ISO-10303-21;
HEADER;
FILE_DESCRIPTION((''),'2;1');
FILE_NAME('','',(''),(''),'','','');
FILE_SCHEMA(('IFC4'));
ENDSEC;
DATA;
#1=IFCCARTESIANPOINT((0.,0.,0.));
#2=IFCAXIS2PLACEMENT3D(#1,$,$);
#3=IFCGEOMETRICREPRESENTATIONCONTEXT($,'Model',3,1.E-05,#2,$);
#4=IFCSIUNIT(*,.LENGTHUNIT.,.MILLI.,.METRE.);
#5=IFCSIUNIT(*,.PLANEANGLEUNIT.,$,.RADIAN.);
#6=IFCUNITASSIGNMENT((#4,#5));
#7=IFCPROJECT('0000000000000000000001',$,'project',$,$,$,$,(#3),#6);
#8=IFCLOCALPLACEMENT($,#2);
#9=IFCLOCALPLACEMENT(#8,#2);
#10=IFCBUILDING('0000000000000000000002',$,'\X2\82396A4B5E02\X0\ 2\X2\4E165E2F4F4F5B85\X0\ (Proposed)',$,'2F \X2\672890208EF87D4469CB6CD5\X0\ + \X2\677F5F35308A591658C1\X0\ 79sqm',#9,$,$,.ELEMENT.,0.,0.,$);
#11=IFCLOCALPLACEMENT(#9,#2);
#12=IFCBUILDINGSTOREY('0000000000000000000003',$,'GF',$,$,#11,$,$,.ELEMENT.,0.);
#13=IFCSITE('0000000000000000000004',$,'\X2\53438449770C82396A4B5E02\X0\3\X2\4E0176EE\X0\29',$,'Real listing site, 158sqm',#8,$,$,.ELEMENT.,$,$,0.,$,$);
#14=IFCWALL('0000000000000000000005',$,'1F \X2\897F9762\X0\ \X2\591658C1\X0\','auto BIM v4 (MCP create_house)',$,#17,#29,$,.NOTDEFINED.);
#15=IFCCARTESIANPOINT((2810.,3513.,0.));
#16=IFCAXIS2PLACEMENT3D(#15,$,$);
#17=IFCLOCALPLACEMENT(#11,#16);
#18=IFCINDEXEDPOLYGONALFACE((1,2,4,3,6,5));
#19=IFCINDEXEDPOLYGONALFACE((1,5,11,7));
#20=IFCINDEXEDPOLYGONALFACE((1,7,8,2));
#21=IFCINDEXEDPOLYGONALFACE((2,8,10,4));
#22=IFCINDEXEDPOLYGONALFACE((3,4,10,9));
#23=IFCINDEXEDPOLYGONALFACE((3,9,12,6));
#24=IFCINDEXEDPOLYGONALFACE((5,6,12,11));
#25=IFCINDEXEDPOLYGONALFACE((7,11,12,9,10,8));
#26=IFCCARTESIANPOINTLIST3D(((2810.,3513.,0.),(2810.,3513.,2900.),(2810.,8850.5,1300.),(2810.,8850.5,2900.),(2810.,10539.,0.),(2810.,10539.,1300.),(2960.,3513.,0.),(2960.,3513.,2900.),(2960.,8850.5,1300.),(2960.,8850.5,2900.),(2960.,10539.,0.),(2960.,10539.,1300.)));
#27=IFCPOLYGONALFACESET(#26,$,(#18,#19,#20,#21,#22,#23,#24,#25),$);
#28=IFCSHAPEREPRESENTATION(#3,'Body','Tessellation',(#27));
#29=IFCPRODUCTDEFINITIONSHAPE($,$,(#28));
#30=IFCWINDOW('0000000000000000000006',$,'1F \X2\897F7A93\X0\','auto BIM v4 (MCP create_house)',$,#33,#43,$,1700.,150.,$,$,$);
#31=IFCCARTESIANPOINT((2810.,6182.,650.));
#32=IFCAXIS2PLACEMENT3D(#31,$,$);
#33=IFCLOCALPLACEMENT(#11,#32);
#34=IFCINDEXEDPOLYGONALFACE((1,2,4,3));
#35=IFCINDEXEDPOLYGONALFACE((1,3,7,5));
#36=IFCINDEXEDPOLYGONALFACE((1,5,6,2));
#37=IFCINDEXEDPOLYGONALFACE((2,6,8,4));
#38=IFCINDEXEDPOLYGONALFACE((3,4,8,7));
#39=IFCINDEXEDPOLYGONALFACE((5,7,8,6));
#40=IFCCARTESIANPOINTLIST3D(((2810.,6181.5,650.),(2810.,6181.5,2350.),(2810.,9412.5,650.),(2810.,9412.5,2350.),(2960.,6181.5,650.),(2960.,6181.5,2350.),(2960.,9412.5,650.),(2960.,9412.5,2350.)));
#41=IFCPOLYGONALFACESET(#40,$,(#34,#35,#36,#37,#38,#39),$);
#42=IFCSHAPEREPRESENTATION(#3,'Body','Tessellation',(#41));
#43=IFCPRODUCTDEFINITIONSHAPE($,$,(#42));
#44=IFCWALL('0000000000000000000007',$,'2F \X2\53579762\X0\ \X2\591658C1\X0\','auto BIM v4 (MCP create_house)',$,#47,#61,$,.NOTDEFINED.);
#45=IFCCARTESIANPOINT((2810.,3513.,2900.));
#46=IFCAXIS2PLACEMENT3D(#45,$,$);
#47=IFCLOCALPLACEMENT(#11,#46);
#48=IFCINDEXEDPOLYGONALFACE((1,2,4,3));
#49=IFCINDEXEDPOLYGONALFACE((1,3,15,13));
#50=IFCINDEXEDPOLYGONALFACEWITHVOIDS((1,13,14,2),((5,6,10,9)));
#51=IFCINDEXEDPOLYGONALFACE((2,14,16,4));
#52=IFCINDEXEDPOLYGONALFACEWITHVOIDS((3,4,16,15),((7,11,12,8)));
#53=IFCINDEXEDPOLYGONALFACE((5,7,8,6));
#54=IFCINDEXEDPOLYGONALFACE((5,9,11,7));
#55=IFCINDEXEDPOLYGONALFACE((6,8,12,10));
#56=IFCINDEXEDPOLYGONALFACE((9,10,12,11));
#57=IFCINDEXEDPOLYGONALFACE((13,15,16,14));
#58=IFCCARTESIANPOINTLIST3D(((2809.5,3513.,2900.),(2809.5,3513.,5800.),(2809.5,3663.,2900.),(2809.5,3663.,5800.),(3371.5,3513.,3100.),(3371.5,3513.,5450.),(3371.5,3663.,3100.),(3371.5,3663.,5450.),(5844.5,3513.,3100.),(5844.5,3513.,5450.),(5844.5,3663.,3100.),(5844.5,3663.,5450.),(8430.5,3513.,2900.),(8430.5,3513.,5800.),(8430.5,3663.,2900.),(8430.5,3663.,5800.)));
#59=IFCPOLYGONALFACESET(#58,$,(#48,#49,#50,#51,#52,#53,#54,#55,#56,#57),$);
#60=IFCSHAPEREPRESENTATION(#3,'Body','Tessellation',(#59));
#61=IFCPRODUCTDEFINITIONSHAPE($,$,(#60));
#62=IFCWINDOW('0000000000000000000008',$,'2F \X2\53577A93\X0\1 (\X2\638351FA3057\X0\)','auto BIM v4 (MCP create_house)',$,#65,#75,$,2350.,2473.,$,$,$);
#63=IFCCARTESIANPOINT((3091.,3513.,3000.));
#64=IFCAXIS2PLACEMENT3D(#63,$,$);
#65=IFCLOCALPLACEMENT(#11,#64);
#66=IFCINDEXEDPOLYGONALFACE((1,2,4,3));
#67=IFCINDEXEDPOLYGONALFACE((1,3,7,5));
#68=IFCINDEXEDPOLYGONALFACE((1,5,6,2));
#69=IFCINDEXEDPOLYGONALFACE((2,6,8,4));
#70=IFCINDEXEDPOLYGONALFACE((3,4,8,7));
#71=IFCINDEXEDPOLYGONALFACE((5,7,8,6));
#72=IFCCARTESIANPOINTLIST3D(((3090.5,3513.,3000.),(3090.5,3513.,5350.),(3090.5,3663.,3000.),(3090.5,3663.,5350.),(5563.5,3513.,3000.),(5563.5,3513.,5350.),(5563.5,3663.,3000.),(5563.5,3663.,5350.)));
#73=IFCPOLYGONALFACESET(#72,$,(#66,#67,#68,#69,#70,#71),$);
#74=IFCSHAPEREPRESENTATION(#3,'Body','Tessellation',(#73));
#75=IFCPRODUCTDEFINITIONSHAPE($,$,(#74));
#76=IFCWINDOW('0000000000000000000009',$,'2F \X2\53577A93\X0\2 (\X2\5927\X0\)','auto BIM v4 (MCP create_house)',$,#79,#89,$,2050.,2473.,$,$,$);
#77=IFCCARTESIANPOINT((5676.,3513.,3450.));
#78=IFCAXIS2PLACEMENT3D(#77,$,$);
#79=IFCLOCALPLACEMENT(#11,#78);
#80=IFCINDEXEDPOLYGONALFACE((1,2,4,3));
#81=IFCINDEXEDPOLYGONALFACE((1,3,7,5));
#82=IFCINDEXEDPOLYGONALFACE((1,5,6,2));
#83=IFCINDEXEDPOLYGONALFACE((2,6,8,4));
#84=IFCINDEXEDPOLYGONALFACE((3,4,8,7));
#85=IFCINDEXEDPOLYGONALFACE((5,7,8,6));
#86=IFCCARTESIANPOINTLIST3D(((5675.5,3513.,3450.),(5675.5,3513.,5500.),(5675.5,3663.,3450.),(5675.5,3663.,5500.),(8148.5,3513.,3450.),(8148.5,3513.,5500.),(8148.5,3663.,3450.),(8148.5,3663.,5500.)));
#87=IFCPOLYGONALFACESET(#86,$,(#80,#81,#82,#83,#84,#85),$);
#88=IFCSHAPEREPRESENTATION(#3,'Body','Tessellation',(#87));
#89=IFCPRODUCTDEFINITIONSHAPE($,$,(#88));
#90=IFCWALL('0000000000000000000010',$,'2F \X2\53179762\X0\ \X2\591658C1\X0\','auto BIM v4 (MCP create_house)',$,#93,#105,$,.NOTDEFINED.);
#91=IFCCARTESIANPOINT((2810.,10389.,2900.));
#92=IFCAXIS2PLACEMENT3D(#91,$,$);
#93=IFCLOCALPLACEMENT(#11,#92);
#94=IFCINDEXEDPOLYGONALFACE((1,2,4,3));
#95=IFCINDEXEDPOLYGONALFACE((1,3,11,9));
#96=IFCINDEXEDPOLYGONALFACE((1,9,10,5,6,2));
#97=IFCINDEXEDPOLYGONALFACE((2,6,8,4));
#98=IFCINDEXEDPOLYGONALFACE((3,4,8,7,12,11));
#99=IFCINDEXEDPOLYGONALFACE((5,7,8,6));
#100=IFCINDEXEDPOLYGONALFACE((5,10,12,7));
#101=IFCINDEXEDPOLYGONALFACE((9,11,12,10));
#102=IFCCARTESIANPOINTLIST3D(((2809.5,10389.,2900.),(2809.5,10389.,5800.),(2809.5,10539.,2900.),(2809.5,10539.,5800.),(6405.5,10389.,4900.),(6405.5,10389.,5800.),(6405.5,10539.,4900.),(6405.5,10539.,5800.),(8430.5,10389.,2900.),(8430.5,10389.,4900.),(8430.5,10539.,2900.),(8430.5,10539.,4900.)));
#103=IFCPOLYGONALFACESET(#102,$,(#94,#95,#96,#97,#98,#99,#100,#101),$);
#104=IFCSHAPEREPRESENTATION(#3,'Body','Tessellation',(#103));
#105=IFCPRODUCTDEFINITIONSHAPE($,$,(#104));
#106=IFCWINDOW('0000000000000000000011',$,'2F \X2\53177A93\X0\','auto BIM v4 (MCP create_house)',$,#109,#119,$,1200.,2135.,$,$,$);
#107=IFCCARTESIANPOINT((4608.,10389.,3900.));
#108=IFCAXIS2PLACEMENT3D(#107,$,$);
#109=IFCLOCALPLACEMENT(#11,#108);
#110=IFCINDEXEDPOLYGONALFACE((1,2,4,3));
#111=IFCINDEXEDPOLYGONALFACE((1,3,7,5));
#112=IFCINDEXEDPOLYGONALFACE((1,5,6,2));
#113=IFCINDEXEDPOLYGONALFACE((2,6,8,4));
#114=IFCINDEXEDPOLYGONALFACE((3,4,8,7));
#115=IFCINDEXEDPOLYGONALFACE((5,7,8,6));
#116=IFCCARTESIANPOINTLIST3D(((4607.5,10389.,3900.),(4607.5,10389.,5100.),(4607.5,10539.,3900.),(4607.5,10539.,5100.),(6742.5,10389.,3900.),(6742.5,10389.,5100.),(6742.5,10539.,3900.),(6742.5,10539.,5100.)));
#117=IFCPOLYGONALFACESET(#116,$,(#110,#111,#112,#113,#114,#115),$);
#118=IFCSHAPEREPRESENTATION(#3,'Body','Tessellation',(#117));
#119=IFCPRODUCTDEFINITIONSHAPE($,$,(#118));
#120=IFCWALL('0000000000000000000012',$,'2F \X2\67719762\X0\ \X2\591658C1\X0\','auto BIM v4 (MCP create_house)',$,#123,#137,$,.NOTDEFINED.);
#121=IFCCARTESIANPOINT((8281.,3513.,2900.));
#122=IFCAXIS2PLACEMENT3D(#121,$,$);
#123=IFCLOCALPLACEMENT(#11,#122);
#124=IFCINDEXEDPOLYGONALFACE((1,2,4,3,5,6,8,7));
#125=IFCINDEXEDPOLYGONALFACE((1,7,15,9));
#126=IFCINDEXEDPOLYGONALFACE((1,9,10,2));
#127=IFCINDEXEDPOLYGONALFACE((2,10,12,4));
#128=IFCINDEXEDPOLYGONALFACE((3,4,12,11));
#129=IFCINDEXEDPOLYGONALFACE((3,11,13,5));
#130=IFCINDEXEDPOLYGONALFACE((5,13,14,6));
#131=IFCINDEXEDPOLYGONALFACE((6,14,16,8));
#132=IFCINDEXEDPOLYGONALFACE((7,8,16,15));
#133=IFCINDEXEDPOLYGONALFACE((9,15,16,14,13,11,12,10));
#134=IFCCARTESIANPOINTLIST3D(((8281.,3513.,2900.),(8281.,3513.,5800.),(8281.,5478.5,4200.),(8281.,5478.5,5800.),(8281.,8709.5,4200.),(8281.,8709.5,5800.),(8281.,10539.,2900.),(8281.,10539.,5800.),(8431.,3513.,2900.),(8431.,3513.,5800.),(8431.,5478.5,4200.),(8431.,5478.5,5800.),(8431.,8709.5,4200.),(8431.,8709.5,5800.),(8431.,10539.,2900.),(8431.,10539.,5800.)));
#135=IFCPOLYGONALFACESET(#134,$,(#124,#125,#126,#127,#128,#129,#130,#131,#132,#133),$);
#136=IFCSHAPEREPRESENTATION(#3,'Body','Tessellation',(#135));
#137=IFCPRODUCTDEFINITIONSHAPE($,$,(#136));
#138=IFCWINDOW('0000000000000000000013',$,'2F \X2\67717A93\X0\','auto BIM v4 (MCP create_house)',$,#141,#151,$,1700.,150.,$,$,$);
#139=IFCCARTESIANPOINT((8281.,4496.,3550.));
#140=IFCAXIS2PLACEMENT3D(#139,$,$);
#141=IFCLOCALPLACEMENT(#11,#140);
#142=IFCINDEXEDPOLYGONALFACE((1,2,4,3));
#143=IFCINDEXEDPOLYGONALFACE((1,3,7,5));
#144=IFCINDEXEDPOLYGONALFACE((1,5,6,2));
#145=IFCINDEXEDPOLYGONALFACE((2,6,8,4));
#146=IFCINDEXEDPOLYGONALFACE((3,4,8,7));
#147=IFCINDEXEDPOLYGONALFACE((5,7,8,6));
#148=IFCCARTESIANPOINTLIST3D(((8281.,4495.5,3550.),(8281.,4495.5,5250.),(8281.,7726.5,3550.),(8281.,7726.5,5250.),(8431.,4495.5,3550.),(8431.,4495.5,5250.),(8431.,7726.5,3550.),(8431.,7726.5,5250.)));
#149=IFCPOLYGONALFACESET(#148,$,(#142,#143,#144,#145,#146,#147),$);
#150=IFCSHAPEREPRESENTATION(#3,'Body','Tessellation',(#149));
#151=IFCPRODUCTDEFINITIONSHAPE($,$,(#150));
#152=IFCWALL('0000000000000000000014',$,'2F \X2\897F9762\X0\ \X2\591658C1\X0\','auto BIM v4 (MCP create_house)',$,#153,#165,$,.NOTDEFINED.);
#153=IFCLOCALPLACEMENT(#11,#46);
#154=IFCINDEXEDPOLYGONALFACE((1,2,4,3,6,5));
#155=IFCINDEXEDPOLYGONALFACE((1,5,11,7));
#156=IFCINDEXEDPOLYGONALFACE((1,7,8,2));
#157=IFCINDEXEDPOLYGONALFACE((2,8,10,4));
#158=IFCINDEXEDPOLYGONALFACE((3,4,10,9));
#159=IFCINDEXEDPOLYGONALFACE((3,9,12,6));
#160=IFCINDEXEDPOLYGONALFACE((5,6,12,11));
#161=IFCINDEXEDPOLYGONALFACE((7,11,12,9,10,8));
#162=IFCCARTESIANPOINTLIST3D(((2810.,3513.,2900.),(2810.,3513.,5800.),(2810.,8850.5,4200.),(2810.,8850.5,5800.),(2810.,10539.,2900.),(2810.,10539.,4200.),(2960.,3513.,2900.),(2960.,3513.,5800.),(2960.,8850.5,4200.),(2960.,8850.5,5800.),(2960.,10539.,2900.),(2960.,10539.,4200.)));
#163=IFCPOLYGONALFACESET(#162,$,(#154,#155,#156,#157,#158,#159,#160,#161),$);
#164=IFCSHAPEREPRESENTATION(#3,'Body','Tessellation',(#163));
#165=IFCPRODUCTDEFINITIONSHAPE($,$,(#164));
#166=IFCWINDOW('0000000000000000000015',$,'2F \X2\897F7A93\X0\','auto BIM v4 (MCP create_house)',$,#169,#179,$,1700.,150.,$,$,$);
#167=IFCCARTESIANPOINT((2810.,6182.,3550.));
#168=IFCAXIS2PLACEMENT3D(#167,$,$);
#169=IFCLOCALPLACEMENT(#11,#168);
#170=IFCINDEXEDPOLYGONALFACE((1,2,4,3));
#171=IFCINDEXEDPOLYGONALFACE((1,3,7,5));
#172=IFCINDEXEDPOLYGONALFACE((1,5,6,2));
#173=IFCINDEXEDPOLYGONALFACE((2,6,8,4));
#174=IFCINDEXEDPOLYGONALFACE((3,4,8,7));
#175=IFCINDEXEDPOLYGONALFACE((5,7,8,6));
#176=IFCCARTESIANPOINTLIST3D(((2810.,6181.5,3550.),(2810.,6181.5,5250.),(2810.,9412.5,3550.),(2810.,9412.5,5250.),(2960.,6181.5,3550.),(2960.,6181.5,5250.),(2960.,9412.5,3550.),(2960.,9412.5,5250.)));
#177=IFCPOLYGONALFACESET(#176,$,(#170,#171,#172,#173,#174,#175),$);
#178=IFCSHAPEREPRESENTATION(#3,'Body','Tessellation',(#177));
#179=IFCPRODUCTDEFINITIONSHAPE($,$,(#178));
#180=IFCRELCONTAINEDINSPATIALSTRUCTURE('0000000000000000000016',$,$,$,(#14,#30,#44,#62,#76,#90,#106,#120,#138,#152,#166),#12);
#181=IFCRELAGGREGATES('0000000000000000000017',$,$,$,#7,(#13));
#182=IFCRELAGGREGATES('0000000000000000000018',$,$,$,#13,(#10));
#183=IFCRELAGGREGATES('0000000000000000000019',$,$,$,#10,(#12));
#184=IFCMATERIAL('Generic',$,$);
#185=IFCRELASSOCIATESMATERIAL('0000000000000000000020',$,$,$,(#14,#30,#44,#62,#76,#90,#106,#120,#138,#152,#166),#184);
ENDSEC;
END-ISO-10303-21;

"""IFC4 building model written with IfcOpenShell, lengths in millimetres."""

from ifc_helpers import new_model, si_unit, frame, frame_2d, origin, place, context, project, spatial, rectangle, extrude, material, element, fill, save


model = new_model("IFC4")

# Units and contexts
model_context = context("Model", 3, precision=1e-05, world=origin())
ifc_project = project(units=[si_unit("LENGTHUNIT", "METRE", prefix="MILLI"), si_unit("PLANEANGLEUNIT", "RADIAN")], contexts=[model_context])

# Site, building, storey
site_placement = place(None, origin())
site = spatial("IfcSite", under=ifc_project, at=site_placement, Name="千葉県船橋市3丁目29", ObjectType="Real listing site, 158sqm", CompositionType="ELEMENT", RefElevation=0.0)
building_placement = place(site_placement, origin())
building = spatial("IfcBuilding", under=site, at=building_placement, Name="船橋市 2世帯住宅 (Proposed)", ObjectType="2F 木造軸組構法 + 板張り外壁 79sqm", CompositionType="ELEMENT", ElevationOfRefHeight=0.0, ElevationOfTerrain=0.0)
storey_placement = place(building_placement, origin())
storey = spatial("IfcBuildingStorey", under=building, at=storey_placement, Name="GF", CompositionType="ELEMENT", Elevation=0.0)

# Shared definitions
ifc_material = material(Name="Generic")

# Wall, opening, window
wall_1_placement = place(storey_placement, frame((2810.0, 3513.0, 0.0)))
wall_1 = element("IfcWall", 1, at=wall_1_placement, inside=storey, material=ifc_material, Name="1F 西面 外壁", Description="auto BIM v4 (MCP create_house)", PredefinedType="NOTDEFINED", context=model_context, shape_type="SweptSolid", body=[
    extrude(rectangle(XDim=150.0, YDim=7026.0, at=frame_2d((75.0, 3513.0))), frame((2810.0, 3513.0, 0.0)), (0.0, 0.0, 1.0), 2900.0),
])
opening_1_placement = place(storey_placement, frame((2810.0, 6182.0, 650.0)))
opening_1 = element("IfcOpeningElement", 2, at=opening_1_placement, cuts=wall_1, PredefinedType="NOTDEFINED", context=model_context, shape_type="SweptSolid", body=[
    extrude(rectangle(XDim=150.0, YDim=3231.0, at=frame_2d((75.0, 1615.0))), frame((2810.0, 6182.0, 650.0)), (0.0, 0.0, 1.0), 1700.0),
])
window_1_placement = place(storey_placement, frame((2810.0, 6182.0, 650.0)))
window_1 = element("IfcWindow", 3, at=window_1_placement, inside=storey, material=ifc_material, Name="1F 西窓", Description="auto BIM v4 (MCP create_house)", OverallHeight=1700.0, OverallWidth=150.0, context=model_context, shape_type="SweptSolid", body=[
    extrude(rectangle(XDim=150.0, YDim=3231.0, at=frame_2d((75.0, 1615.0))), frame((2810.0, 6182.0, 650.0)), (0.0, 0.0, 1.0), 1700.0),
])
fill(opening_1, window_1)

# Wall, openings, windows
wall_2_placement = place(storey_placement, frame((2810.0, 3513.0, 2900.0)))
wall_2 = element("IfcWall", 4, at=wall_2_placement, inside=storey, material=ifc_material, Name="2F 南面 外壁", Description="auto BIM v4 (MCP create_house)", PredefinedType="NOTDEFINED", context=model_context, shape_type="SweptSolid", body=[
    extrude(rectangle(XDim=5621.0, YDim=150.0, at=frame_2d((2810.0, 75.0))), frame((2810.0, 3513.0, 2900.0)), (0.0, 0.0, 1.0), 2900.0),
])
opening_2_placement = place(storey_placement, frame((3091.0, 3513.0, 3000.0)))
opening_2 = element("IfcOpeningElement", 5, at=opening_2_placement, cuts=wall_2, PredefinedType="NOTDEFINED", context=model_context, shape_type="SweptSolid", body=[
    extrude(rectangle(XDim=2473.0, YDim=150.0, at=frame_2d((1236.0, 75.0))), frame((3091.0, 3513.0, 3000.0)), (0.0, 0.0, 1.0), 2350.0),
])
opening_3_placement = place(storey_placement, frame((5676.0, 3513.0, 3450.0)))
opening_3 = element("IfcOpeningElement", 6, at=opening_3_placement, cuts=wall_2, PredefinedType="NOTDEFINED", context=model_context, shape_type="SweptSolid", body=[
    extrude(rectangle(XDim=2473.0, YDim=150.0, at=frame_2d((1236.0, 75.0))), frame((5676.0, 3513.0, 3450.0)), (0.0, 0.0, 1.0), 2050.0),
])
window_2_placement = place(storey_placement, frame((3091.0, 3513.0, 3000.0)))
window_2 = element("IfcWindow", 7, at=window_2_placement, inside=storey, material=ifc_material, Name="2F 南窓1 (掃出し)", Description="auto BIM v4 (MCP create_house)", OverallHeight=2350.0, OverallWidth=2473.0, context=model_context, shape_type="SweptSolid", body=[
    extrude(rectangle(XDim=2473.0, YDim=150.0, at=frame_2d((1236.0, 75.0))), frame((3091.0, 3513.0, 3000.0)), (0.0, 0.0, 1.0), 2350.0),
])
fill(opening_2, window_2)
window_3_placement = place(storey_placement, frame((5676.0, 3513.0, 3450.0)))
window_3 = element("IfcWindow", 8, at=window_3_placement, inside=storey, material=ifc_material, Name="2F 南窓2 (大)", Description="auto BIM v4 (MCP create_house)", OverallHeight=2050.0, OverallWidth=2473.0, context=model_context, shape_type="SweptSolid", body=[
    extrude(rectangle(XDim=2473.0, YDim=150.0, at=frame_2d((1236.0, 75.0))), frame((5676.0, 3513.0, 3450.0)), (0.0, 0.0, 1.0), 2050.0),
])
fill(opening_3, window_3)

# Walls, openings, windows
wall_3_placement = place(storey_placement, frame((2810.0, 10389.0, 2900.0)))
wall_3 = element("IfcWall", 9, at=wall_3_placement, inside=storey, material=ifc_material, Name="2F 北面 外壁", Description="auto BIM v4 (MCP create_house)", PredefinedType="NOTDEFINED", context=model_context, shape_type="SweptSolid", body=[
    extrude(rectangle(XDim=5621.0, YDim=150.0, at=frame_2d((2810.0, 75.0))), frame((2810.0, 10389.0, 2900.0)), (0.0, 0.0, 1.0), 2900.0),
])
opening_4_placement = place(storey_placement, frame((4608.0, 10389.0, 3900.0)))
opening_4 = element("IfcOpeningElement", 10, at=opening_4_placement, cuts=wall_3, PredefinedType="NOTDEFINED", context=model_context, shape_type="SweptSolid", body=[
    extrude(rectangle(XDim=2135.0, YDim=150.0, at=frame_2d((1067.0, 75.0))), frame((4608.0, 10389.0, 3900.0)), (0.0, 0.0, 1.0), 1200.0),
])
window_4_placement = place(storey_placement, frame((4608.0, 10389.0, 3900.0)))
window_4 = element("IfcWindow", 11, at=window_4_placement, inside=storey, material=ifc_material, Name="2F 北窓", Description="auto BIM v4 (MCP create_house)", OverallHeight=1200.0, OverallWidth=2135.0, context=model_context, shape_type="SweptSolid", body=[
    extrude(rectangle(XDim=2135.0, YDim=150.0, at=frame_2d((1067.0, 75.0))), frame((4608.0, 10389.0, 3900.0)), (0.0, 0.0, 1.0), 1200.0),
])
fill(opening_4, window_4)
wall_4_placement = place(storey_placement, frame((8281.0, 3513.0, 2900.0)))
wall_4 = element("IfcWall", 12, at=wall_4_placement, inside=storey, material=ifc_material, Name="2F 東面 外壁", Description="auto BIM v4 (MCP create_house)", PredefinedType="NOTDEFINED", context=model_context, shape_type="SweptSolid", body=[
    extrude(rectangle(XDim=150.0, YDim=7026.0, at=frame_2d((75.0, 3513.0))), frame((8281.0, 3513.0, 2900.0)), (0.0, 0.0, 1.0), 2900.0),
])
opening_5_placement = place(storey_placement, frame((8281.0, 4496.0, 3550.0)))
opening_5 = element("IfcOpeningElement", 13, at=opening_5_placement, cuts=wall_4, PredefinedType="NOTDEFINED", context=model_context, shape_type="SweptSolid", body=[
    extrude(rectangle(XDim=150.0, YDim=3231.0, at=frame_2d((75.0, 1615.0))), frame((8281.0, 4496.0, 3550.0)), (0.0, 0.0, 1.0), 1700.0),
])
window_5_placement = place(storey_placement, frame((8281.0, 4496.0, 3550.0)))
window_5 = element("IfcWindow", 14, at=window_5_placement, inside=storey, material=ifc_material, Name="2F 東窓", Description="auto BIM v4 (MCP create_house)", OverallHeight=1700.0, OverallWidth=150.0, context=model_context, shape_type="SweptSolid", body=[
    extrude(rectangle(XDim=150.0, YDim=3231.0, at=frame_2d((75.0, 1615.0))), frame((8281.0, 4496.0, 3550.0)), (0.0, 0.0, 1.0), 1700.0),
])
fill(opening_5, window_5)
wall_5_placement = place(storey_placement, frame((2810.0, 3513.0, 2900.0)))
wall_5 = element("IfcWall", 15, at=wall_5_placement, inside=storey, material=ifc_material, Name="2F 西面 外壁", Description="auto BIM v4 (MCP create_house)", PredefinedType="NOTDEFINED", context=model_context, shape_type="SweptSolid", body=[
    extrude(rectangle(XDim=150.0, YDim=7026.0, at=frame_2d((75.0, 3513.0))), frame((2810.0, 3513.0, 2900.0)), (0.0, 0.0, 1.0), 2900.0),
])
opening_6_placement = place(storey_placement, frame((2810.0, 6182.0, 3550.0)))
opening_6 = element("IfcOpeningElement", 16, at=opening_6_placement, cuts=wall_5, PredefinedType="NOTDEFINED", context=model_context, shape_type="SweptSolid", body=[
    extrude(rectangle(XDim=150.0, YDim=3231.0, at=frame_2d((75.0, 1615.0))), frame((2810.0, 6182.0, 3550.0)), (0.0, 0.0, 1.0), 1700.0),
])
window_6_placement = place(storey_placement, frame((2810.0, 6182.0, 3550.0)))
window_6 = element("IfcWindow", 17, at=window_6_placement, inside=storey, material=ifc_material, Name="2F 西窓", Description="auto BIM v4 (MCP create_house)", OverallHeight=1700.0, OverallWidth=150.0, context=model_context, shape_type="SweptSolid", body=[
    extrude(rectangle(XDim=150.0, YDim=3231.0, at=frame_2d((75.0, 1615.0))), frame((2810.0, 6182.0, 3550.0)), (0.0, 0.0, 1.0), 1700.0),
])
fill(opening_6, window_6)

save(model, "model.ifc")
